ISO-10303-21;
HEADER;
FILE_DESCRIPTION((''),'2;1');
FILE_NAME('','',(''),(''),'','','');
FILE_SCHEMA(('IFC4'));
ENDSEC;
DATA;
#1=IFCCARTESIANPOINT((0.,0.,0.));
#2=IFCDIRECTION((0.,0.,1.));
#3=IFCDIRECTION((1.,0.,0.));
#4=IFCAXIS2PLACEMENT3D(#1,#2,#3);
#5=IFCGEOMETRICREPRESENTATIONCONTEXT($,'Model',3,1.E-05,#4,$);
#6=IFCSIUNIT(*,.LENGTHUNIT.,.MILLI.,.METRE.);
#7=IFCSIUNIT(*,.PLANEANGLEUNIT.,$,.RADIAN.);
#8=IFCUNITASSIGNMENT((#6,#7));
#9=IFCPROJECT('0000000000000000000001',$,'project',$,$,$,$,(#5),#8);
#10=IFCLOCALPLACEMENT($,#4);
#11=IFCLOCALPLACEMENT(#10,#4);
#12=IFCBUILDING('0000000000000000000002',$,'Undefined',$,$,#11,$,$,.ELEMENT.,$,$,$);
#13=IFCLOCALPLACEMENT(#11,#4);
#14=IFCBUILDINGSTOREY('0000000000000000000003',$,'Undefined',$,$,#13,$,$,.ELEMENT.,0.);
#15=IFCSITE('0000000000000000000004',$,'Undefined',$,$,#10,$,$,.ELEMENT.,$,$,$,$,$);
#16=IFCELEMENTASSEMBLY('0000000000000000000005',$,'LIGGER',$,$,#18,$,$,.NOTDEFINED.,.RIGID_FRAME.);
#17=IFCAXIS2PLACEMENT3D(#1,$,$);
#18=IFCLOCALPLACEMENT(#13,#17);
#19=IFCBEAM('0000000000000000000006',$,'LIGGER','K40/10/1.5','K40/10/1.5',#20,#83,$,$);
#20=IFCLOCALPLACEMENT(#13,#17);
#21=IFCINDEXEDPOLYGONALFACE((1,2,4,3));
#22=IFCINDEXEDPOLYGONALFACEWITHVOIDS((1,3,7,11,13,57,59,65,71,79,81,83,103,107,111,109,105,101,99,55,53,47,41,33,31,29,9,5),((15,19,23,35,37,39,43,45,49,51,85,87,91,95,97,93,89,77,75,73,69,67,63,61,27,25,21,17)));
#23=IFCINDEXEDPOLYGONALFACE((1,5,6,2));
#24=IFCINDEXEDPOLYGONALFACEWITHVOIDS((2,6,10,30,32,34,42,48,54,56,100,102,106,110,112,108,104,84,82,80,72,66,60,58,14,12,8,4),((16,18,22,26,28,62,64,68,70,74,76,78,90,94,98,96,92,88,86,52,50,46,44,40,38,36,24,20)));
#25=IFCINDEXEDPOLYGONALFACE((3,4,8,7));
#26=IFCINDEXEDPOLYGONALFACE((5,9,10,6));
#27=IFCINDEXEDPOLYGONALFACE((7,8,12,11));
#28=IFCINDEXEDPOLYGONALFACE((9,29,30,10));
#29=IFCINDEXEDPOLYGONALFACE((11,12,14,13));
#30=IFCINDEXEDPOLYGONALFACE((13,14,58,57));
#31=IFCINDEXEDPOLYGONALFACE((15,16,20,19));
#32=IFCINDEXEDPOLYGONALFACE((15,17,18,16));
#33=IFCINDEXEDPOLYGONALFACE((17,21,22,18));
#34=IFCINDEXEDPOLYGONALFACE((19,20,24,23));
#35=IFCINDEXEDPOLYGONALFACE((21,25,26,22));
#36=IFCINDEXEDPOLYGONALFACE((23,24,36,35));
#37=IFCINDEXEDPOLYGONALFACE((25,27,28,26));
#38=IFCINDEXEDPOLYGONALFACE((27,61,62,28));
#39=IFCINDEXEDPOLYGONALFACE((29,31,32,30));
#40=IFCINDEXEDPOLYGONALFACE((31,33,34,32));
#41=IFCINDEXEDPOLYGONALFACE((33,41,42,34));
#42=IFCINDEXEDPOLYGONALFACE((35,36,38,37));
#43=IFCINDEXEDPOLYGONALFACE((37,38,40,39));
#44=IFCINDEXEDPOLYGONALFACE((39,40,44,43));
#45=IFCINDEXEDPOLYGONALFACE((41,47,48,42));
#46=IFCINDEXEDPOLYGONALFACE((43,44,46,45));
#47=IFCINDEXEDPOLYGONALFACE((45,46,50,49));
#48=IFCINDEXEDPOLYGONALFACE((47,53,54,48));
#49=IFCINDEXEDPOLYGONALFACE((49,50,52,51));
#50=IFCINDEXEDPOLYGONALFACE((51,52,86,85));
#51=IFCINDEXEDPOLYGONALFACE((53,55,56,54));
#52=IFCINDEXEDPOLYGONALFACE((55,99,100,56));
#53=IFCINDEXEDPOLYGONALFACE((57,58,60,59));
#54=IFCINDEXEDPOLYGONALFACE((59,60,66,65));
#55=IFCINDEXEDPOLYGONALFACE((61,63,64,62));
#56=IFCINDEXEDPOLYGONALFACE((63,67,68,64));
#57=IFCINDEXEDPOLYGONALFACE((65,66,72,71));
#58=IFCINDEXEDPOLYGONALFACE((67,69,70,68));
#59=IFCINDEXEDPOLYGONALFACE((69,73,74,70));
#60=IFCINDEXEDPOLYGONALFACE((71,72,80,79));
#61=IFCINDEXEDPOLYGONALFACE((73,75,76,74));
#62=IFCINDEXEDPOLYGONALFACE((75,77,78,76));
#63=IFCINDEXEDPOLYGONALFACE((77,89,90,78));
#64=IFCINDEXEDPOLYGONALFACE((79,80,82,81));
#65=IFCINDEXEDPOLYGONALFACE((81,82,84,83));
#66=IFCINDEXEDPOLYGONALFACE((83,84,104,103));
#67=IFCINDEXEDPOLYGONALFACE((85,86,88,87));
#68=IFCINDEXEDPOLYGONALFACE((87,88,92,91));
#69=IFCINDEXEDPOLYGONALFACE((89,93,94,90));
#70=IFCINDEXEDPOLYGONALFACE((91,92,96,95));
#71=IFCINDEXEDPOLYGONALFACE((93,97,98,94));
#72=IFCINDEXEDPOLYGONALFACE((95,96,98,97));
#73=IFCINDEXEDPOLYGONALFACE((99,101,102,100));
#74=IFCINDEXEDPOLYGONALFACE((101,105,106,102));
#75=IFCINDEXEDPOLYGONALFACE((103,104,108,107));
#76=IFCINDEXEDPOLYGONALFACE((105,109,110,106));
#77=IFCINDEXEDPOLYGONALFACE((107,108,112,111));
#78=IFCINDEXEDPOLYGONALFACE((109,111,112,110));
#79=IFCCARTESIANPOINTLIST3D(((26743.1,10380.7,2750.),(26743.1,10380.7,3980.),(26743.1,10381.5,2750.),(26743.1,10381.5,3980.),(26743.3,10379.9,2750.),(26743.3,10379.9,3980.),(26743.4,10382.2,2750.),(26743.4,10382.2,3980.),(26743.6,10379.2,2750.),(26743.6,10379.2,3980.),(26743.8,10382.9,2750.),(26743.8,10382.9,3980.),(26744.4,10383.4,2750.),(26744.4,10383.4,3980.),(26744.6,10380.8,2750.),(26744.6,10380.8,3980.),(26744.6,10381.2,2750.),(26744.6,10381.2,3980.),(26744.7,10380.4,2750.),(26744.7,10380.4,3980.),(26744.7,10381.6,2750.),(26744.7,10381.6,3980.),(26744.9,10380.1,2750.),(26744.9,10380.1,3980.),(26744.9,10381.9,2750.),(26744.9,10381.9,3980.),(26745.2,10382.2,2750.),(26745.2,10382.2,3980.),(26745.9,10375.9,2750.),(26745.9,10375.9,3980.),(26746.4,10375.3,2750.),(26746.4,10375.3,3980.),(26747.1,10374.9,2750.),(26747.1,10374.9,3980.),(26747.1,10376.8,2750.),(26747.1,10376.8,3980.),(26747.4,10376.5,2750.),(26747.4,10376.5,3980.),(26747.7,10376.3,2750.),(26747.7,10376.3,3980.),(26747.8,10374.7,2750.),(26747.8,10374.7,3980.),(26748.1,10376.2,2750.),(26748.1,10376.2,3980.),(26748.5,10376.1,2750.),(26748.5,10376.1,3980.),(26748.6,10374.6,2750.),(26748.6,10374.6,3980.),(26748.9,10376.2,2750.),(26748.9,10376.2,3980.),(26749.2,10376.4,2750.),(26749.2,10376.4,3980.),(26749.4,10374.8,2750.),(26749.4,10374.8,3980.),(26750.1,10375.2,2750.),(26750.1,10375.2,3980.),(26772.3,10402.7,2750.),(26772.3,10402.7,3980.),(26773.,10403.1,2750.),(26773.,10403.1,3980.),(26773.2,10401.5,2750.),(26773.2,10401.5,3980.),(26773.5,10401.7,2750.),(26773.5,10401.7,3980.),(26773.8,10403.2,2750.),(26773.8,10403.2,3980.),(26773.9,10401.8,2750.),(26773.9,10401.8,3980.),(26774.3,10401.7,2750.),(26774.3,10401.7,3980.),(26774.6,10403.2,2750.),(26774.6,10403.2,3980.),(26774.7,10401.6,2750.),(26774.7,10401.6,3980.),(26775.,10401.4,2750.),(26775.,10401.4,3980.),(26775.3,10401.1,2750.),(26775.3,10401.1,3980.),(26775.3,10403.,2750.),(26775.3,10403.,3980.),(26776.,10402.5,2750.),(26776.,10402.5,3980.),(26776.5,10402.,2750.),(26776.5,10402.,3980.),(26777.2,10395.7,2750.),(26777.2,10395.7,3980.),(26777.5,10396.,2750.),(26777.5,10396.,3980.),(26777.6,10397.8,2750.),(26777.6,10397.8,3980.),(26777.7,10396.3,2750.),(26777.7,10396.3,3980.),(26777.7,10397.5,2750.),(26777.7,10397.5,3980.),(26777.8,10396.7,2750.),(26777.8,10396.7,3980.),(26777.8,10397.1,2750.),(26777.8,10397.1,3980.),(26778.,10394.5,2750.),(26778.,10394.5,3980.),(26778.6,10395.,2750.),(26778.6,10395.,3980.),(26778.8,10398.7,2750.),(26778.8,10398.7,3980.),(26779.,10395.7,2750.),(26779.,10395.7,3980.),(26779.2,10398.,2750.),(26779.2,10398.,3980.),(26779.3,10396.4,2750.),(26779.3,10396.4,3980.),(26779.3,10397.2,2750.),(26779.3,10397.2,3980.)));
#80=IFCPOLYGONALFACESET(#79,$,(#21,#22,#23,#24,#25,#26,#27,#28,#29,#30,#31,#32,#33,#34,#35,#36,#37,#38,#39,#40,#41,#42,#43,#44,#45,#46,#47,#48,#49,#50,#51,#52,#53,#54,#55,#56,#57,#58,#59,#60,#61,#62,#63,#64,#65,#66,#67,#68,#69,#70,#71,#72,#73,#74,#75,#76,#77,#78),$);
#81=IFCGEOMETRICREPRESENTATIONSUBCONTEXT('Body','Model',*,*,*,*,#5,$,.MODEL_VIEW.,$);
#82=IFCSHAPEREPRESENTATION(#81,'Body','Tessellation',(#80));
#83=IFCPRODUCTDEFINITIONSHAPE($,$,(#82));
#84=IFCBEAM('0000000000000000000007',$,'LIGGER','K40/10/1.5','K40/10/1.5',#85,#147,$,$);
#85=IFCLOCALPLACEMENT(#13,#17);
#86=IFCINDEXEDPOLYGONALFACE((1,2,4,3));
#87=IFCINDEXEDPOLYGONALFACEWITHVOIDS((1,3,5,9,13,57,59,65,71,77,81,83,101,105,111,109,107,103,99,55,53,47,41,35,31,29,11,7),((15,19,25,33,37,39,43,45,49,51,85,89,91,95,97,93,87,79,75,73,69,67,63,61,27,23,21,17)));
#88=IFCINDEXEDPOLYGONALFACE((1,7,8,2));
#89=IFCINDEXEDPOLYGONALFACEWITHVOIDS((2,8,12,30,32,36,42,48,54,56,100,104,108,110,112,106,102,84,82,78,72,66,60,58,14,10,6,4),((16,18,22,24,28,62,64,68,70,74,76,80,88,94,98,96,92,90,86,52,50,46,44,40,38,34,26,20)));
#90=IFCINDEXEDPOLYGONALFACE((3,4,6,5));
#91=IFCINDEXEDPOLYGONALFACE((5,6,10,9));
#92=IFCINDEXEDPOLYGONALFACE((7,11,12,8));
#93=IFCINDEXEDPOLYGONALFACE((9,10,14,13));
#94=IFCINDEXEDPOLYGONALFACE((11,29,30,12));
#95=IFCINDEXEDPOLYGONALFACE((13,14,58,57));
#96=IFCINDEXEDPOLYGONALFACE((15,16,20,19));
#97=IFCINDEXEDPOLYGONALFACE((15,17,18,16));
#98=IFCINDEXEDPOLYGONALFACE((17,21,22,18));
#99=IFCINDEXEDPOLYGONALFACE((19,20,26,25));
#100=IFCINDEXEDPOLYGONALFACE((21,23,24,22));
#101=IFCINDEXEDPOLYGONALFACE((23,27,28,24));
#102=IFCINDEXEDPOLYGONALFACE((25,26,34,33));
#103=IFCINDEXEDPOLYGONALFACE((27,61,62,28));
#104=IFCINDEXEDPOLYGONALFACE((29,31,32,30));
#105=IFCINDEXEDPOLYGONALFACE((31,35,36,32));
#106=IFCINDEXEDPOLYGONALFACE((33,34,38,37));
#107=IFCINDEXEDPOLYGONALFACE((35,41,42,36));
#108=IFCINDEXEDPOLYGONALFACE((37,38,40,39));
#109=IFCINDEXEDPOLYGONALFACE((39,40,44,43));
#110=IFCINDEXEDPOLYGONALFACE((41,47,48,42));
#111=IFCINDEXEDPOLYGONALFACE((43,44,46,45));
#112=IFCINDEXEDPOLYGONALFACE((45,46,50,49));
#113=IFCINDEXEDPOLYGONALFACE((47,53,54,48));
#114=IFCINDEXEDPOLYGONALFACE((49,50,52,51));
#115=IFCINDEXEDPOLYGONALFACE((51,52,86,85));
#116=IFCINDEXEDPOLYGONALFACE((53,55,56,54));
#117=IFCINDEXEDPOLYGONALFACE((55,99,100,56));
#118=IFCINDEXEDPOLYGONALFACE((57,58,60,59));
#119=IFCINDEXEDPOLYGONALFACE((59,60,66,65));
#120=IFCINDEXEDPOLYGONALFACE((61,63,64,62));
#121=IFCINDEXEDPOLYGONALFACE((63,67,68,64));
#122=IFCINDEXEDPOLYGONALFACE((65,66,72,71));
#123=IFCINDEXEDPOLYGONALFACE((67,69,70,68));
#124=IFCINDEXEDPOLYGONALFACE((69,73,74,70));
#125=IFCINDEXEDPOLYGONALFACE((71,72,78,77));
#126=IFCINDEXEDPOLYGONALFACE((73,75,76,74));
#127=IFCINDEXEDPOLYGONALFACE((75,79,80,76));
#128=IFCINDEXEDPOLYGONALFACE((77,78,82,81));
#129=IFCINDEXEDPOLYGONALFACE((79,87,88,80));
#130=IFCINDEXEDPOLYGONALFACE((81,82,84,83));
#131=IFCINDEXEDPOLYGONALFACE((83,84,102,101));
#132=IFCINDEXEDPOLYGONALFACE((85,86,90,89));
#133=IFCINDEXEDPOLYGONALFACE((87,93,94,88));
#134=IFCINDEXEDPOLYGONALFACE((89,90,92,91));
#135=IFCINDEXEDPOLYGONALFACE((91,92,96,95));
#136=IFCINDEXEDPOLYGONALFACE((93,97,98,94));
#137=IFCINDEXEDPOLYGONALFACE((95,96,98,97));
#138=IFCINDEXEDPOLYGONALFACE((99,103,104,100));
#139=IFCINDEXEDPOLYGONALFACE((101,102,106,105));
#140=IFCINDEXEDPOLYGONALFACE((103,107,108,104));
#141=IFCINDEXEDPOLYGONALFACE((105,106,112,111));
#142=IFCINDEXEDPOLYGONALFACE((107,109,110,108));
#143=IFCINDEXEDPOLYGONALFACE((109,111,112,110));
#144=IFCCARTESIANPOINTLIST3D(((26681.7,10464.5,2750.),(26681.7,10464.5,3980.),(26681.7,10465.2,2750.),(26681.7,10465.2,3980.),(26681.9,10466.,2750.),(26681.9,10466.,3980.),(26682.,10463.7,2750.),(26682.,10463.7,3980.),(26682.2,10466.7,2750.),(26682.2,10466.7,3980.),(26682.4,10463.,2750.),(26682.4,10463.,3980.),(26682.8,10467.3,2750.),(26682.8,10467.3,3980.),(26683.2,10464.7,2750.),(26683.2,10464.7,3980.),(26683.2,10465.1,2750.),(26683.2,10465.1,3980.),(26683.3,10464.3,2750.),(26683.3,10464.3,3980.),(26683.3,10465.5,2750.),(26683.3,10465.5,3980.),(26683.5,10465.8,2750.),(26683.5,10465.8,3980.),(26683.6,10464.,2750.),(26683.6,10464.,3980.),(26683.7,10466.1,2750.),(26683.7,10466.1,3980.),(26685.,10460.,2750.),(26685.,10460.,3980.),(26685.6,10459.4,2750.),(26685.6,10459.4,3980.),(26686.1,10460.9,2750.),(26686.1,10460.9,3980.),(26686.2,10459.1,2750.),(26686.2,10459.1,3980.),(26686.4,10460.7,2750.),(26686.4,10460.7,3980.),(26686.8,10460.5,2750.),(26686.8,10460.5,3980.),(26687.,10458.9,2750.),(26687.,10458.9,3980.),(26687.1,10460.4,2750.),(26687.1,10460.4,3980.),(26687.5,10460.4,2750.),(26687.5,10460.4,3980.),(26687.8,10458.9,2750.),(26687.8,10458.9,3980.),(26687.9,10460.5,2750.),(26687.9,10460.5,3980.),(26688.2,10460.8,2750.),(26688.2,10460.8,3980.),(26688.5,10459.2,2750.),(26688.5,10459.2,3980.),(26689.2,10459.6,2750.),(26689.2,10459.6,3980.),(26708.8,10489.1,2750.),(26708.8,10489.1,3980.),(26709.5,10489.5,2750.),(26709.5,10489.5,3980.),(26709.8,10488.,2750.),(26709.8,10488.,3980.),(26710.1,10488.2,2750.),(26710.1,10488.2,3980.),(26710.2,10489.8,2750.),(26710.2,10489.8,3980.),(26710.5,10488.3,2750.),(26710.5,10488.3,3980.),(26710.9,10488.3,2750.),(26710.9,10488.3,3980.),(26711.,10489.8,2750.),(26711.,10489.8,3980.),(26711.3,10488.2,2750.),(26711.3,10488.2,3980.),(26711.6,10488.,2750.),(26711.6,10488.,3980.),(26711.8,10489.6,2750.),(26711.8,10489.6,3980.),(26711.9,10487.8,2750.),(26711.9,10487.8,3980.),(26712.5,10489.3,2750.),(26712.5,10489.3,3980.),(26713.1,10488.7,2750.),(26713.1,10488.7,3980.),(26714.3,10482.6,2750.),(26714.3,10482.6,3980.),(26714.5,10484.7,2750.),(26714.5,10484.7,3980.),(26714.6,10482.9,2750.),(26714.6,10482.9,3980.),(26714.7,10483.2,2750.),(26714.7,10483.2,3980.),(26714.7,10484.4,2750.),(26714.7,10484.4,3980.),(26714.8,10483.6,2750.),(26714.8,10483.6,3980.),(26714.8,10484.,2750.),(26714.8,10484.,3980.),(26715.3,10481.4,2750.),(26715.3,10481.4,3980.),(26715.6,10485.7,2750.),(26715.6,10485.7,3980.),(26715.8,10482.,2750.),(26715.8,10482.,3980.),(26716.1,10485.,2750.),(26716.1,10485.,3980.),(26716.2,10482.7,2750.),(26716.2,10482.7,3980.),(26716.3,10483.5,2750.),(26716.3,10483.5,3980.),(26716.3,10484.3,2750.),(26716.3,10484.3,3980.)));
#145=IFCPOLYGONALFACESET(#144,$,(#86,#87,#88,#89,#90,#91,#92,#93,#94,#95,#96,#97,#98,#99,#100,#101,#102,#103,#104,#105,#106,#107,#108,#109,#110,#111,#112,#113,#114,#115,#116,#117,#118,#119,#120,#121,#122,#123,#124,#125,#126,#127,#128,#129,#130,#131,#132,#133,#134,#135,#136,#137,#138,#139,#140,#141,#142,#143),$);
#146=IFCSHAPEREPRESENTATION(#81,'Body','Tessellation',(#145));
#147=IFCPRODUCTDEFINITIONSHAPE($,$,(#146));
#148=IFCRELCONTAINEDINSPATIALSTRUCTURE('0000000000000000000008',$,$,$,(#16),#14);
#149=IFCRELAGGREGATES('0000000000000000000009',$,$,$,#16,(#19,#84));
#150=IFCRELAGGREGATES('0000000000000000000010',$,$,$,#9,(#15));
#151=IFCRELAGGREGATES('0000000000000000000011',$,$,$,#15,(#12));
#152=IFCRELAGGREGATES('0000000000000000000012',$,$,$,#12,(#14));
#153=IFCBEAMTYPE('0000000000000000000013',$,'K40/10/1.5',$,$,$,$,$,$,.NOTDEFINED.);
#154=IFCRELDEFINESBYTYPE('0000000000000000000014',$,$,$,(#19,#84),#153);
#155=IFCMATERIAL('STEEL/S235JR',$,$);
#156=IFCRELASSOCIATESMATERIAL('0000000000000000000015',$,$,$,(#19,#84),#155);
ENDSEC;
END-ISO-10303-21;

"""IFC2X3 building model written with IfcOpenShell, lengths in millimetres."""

from ifc_helpers import new_model, si_unit, frame, origin_with_axes, origin_2d_with_axis, place, context, subcontext, project, spatial, hollow_rectangle, extrude, material, type_object, element, aggregate, save


model = new_model("IFC2X3")

# Units and contexts
model_context = context("Model", 3, precision=1e-05, world=origin_with_axes())
body_context = subcontext(model_context, "Body", "Model", "MODEL_VIEW")
ifc_project = project(units=[si_unit("LENGTHUNIT", "METRE", prefix="MILLI"), si_unit("PLANEANGLEUNIT", "RADIAN")], contexts=[model_context])

# Site, building, storey
site_placement = place(None, origin_with_axes())
site = spatial("IfcSite", under=ifc_project, at=site_placement, Name="Undefined", CompositionType="ELEMENT")
building_placement = place(site_placement, origin_with_axes())
building = spatial("IfcBuilding", under=site, at=building_placement, Name="Undefined", CompositionType="ELEMENT")
storey_placement = place(building_placement, origin_with_axes())
storey = spatial("IfcBuildingStorey", under=building, at=storey_placement, Name="Undefined", CompositionType="ELEMENT", Elevation=0.0)

# Element assembly
ifc_material_1 = material(Name="STEEL/S235JR")
assembly_1_placement = place(storey_placement, origin_with_axes())
assembly_1 = element("IfcElementAssembly", 1, at=assembly_1_placement, inside=storey, Name="LIGGER", AssemblyPlace="NOTDEFINED", PredefinedType="RIGID_FRAME")
beam_type_1 = type_object("IfcBeamType", Name="K40/10/1.5", PredefinedType="NOTDEFINED")

# Beams
beam_1_placement = place(assembly_1_placement, frame((26761.2, 10388.9, 3980.0), z_axis=(0.822555, 0.568686, 0.0), x_axis=(0.0, 0.0, -1.0)))
beam_1 = element("IfcBeam", 2, at=beam_1_placement, type_object=beam_type_1, material=ifc_material_1, Name="LIGGER", Description="K40/10/1.5", ObjectType="K40/10/1.5", context=body_context, shape_type="SweptSolid", body=[
    extrude(hollow_rectangle(XDim=10.0, YDim=40.0, WallThickness=1.5, InnerFilletRadius=1.5, OuterFilletRadius=3.0, at=origin_2d_with_axis()), frame((1230.0, 0.0, 0.0), z_axis=(-1.0, 0.0, 0.0), x_axis=(0.0, -1.0, 0.0)), (0.0, 0.0, 1.0), 1230.0),
])
beam_2_placement = place(assembly_1_placement, frame((26699.0, 10474.4, 3980.0), z_axis=(0.766508, 0.642235, 0.0), x_axis=(0.0, 0.0, -1.0)))
beam_2 = element("IfcBeam", 3, at=beam_2_placement, type_object=beam_type_1, material=ifc_material_1, Name="LIGGER", Description="K40/10/1.5", ObjectType="K40/10/1.5", context=body_context, shape_type="SweptSolid", body=[
    extrude(hollow_rectangle(XDim=10.0, YDim=40.0, WallThickness=1.5, InnerFilletRadius=1.5, OuterFilletRadius=3.0, at=origin_2d_with_axis()), frame((1230.0, 0.0, 0.0), z_axis=(-1.0, 0.0, 0.0), x_axis=(0.0, -1.0, 0.0)), (0.0, 0.0, 1.0), 1230.0),
])

aggregate(assembly_1, [beam_1, beam_2])

save(model, "model.ifc")
